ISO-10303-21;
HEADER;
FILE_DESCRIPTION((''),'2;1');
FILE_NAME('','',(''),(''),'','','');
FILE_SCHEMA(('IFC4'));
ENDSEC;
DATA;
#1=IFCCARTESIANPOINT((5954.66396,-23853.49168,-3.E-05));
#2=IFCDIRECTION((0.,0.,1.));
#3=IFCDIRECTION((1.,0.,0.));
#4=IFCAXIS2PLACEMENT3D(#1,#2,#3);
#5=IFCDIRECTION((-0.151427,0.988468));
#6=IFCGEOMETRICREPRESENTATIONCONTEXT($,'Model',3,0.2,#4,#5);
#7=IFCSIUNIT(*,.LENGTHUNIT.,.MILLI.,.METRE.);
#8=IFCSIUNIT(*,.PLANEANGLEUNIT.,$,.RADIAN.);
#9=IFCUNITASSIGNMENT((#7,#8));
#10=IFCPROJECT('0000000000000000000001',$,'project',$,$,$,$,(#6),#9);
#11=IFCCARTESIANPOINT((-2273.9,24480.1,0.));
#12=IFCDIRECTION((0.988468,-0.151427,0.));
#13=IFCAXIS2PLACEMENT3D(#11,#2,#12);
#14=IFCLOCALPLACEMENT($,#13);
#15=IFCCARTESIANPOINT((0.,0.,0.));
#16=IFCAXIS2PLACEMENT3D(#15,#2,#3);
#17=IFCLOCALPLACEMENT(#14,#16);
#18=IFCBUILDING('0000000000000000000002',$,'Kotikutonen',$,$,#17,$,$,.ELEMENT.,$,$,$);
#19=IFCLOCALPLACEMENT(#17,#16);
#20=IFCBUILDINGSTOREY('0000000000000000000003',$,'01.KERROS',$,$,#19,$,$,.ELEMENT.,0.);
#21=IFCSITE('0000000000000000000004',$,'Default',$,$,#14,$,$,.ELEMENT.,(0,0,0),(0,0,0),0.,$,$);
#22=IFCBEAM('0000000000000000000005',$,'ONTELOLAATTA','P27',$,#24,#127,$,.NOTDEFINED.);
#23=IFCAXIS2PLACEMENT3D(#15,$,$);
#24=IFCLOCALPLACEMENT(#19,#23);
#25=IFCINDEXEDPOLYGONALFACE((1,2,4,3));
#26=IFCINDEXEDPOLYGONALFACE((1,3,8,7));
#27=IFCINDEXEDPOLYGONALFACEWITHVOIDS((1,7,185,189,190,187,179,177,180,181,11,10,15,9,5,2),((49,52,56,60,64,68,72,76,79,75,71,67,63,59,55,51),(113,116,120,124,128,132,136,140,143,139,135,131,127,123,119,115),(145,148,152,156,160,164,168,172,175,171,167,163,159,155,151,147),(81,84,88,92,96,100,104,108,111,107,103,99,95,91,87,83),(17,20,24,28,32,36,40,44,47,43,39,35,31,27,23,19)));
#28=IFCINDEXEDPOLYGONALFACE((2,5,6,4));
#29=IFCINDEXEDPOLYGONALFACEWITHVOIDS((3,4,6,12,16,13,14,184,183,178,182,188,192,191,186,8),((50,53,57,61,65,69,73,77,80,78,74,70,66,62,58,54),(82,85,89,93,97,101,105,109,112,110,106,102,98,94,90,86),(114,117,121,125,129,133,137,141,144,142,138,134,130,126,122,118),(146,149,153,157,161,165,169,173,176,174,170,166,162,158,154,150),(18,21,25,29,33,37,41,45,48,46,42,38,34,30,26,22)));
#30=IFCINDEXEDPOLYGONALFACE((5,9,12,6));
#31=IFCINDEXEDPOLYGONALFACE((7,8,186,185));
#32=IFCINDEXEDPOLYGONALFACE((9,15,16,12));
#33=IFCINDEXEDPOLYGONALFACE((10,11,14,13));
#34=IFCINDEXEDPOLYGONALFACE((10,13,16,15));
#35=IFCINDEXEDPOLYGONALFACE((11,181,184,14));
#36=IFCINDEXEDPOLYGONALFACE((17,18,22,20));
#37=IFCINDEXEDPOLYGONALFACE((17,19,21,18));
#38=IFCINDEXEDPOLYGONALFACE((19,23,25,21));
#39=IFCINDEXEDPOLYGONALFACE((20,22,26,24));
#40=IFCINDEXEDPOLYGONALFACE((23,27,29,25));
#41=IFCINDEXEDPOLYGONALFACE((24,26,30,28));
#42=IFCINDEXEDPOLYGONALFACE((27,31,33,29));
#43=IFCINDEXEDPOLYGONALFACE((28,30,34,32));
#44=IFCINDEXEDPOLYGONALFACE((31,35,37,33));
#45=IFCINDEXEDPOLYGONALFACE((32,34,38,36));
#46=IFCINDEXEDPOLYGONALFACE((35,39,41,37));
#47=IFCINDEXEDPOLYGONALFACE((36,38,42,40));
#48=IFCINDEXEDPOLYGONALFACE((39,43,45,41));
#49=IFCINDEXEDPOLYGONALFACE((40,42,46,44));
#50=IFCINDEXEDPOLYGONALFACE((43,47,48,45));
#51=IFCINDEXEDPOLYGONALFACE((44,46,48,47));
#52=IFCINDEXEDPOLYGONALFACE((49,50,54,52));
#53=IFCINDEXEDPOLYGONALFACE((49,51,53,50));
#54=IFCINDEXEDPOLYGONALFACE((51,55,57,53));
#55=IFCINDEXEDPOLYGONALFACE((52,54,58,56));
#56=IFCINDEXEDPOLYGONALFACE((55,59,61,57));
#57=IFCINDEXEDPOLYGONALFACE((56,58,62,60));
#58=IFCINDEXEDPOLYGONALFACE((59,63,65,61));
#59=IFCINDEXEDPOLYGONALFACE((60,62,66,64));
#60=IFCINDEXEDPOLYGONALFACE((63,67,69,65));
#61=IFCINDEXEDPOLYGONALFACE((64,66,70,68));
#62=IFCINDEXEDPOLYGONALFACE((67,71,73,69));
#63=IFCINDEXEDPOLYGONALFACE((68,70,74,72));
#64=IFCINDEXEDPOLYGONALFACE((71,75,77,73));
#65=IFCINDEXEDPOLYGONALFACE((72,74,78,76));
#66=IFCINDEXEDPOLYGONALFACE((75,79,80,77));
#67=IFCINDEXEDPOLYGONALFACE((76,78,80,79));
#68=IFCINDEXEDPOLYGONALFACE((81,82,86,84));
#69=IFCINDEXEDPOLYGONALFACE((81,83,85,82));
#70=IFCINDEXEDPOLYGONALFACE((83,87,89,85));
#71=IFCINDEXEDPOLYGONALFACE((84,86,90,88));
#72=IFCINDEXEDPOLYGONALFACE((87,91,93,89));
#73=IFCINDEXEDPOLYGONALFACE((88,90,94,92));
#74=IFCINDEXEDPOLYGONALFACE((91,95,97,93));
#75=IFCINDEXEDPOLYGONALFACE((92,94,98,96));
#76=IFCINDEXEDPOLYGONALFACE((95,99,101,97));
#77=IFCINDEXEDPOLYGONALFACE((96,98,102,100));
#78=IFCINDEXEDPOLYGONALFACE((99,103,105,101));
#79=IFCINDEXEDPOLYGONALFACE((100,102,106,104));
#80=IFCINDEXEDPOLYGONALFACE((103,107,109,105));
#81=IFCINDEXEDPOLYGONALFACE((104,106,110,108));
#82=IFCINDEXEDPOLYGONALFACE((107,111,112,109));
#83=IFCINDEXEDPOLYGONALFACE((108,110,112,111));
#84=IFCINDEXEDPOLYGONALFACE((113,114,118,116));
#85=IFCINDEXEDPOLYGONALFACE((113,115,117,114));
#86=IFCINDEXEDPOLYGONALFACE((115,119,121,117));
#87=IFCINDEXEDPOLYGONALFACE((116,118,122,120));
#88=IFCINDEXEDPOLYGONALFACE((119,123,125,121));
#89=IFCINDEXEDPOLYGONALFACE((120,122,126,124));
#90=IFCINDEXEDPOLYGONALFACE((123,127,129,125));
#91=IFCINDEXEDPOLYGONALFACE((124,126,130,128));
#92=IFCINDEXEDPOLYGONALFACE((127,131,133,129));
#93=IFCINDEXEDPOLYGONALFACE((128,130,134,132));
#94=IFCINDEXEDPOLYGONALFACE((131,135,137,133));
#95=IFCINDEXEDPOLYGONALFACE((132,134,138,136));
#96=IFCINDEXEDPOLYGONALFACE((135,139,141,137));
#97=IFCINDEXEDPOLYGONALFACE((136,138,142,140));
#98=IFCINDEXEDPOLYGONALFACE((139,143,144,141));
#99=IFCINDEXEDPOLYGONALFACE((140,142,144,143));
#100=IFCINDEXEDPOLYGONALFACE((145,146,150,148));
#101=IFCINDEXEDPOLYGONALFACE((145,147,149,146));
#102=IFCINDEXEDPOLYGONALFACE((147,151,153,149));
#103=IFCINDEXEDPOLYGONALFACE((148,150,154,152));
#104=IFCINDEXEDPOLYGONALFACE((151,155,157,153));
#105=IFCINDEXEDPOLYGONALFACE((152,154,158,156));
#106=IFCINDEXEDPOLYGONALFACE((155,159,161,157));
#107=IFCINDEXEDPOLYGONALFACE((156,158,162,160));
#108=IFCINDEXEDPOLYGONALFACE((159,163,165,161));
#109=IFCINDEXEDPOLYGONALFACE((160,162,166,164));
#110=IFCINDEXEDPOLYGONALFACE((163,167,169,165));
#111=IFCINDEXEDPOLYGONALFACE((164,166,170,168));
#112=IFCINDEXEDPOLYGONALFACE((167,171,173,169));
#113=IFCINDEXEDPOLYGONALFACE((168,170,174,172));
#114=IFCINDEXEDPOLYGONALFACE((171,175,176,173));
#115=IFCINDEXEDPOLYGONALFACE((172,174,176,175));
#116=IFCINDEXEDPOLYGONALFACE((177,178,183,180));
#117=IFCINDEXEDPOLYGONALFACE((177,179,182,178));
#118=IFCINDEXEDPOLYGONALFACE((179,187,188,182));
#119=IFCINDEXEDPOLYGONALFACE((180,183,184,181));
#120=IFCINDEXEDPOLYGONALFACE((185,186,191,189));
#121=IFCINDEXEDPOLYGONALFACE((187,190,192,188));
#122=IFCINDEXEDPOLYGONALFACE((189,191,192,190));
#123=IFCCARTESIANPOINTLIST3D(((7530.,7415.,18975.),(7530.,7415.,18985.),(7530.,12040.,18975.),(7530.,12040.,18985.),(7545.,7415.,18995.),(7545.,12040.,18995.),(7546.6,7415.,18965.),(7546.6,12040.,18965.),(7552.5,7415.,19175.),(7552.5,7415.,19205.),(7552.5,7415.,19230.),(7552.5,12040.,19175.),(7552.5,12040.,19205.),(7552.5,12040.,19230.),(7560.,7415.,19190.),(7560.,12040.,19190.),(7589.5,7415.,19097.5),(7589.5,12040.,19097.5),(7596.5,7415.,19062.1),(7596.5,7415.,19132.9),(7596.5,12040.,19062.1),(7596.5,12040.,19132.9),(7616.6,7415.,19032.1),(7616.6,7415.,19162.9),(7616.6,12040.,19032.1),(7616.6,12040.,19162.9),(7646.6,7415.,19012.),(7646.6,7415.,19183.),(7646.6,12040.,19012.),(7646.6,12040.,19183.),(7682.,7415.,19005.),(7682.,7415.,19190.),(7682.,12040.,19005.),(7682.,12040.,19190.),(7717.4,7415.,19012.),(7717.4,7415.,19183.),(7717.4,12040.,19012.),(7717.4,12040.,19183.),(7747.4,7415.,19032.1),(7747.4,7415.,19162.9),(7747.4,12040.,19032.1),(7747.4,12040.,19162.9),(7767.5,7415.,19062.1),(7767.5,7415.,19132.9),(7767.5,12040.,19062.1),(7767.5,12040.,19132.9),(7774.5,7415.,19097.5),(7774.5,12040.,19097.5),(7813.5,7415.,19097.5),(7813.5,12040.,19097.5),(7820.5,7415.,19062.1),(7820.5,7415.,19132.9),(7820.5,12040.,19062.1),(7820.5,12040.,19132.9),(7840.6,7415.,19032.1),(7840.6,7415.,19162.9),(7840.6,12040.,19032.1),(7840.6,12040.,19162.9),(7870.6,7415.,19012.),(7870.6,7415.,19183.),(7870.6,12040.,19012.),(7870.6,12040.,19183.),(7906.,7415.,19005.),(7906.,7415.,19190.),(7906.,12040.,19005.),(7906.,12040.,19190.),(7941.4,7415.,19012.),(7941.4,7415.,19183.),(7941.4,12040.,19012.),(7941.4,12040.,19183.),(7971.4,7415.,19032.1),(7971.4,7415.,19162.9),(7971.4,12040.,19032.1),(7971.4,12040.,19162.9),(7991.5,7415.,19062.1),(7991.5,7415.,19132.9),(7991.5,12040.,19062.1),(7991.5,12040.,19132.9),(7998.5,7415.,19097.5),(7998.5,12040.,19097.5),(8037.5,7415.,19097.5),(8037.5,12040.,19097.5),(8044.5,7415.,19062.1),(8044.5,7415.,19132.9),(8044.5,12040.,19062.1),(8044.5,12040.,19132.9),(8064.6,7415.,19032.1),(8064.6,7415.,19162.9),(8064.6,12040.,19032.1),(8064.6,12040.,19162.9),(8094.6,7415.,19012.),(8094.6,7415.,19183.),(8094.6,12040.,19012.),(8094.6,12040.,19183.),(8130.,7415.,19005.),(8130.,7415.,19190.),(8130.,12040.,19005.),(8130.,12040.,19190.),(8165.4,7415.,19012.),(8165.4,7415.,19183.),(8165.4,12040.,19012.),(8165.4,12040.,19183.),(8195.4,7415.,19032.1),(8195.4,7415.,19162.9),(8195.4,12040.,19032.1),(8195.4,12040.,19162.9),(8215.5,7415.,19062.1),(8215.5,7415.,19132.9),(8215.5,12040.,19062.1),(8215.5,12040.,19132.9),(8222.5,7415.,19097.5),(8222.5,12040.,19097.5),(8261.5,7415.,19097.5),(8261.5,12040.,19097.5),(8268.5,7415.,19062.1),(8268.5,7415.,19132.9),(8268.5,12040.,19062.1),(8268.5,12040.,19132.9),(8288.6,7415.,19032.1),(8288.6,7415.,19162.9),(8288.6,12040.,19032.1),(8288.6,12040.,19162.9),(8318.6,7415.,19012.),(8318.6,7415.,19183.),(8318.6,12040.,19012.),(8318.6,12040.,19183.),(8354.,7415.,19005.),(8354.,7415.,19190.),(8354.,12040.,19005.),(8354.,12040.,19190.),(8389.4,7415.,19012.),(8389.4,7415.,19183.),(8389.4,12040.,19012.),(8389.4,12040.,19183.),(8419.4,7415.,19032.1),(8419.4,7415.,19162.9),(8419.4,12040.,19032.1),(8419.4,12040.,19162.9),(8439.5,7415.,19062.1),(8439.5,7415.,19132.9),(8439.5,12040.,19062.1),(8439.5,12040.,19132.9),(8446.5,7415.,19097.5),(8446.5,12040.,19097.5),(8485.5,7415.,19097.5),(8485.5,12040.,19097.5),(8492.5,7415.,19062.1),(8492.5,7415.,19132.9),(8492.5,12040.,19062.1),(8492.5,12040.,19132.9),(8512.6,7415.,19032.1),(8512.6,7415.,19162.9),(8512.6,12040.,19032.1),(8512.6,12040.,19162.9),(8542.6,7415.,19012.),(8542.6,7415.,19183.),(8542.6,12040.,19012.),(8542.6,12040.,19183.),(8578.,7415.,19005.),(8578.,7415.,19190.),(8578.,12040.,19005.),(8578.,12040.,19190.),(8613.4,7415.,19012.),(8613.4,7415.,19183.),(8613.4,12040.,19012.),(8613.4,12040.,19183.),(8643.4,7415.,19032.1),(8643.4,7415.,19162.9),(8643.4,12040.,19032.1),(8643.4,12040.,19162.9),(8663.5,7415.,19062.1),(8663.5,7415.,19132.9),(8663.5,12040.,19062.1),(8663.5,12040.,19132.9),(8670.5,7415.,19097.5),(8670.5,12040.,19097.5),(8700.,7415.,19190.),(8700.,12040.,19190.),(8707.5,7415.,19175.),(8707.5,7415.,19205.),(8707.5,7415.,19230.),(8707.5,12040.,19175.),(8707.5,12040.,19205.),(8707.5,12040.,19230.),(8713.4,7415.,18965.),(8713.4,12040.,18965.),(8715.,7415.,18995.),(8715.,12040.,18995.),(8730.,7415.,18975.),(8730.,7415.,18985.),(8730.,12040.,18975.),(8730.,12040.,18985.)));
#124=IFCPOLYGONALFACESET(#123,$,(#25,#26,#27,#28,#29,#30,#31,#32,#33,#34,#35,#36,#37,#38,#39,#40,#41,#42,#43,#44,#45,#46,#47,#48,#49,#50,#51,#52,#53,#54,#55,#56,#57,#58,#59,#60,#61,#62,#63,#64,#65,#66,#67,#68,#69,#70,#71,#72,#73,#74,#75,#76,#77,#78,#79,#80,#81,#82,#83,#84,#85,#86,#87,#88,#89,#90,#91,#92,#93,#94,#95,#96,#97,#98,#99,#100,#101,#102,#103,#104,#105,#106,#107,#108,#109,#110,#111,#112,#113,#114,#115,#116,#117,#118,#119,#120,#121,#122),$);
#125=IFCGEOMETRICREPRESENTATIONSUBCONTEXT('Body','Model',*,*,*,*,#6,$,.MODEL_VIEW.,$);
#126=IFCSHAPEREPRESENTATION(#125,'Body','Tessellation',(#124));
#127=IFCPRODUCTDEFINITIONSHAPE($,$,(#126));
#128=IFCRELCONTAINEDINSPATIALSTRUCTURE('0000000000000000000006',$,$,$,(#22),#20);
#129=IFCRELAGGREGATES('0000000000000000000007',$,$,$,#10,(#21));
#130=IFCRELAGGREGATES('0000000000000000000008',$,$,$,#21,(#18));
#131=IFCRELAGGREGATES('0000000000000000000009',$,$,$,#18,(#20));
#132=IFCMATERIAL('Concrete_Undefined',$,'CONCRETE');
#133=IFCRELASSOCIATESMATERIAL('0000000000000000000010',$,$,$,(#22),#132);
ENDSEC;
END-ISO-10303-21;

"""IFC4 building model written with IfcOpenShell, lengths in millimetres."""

from ifc_helpers import new_model, si_unit, direction, frame, origin_with_axes, place, context, subcontext, project, spatial, line, indexed_curve, outline, extrude, material, element, save


model = new_model("IFC4")

# Units and contexts
model_context = context("Model", 3, precision=0.2, world=frame((5954.66396, -23853.49168, -3e-05), z_axis=(0.0, 0.0, 1.0), x_axis=(1.0, 0.0, 0.0)), true_north=direction((-0.151427, 0.988468)))
body_context = subcontext(model_context, "Body", "Model", "MODEL_VIEW")
ifc_project = project(units=[si_unit("LENGTHUNIT", "METRE", prefix="MILLI"), si_unit("PLANEANGLEUNIT", "RADIAN")], contexts=[model_context])

# Site, building, storey
site_placement = place(None, frame((-2273.9, 24480.1, 0.0), z_axis=(0.0, 0.0, 1.0), x_axis=(0.988468, -0.151427, 0.0)))
site = spatial("IfcSite", under=ifc_project, at=site_placement, Name="Default", CompositionType="ELEMENT", RefLatitude=(0, 0, 0), RefLongitude=(0, 0, 0), RefElevation=0.0)
building_placement = place(site_placement, origin_with_axes())
building = spatial("IfcBuilding", under=site, at=building_placement, Name="Kotikutonen", CompositionType="ELEMENT")
storey_placement = place(building_placement, origin_with_axes())
storey = spatial("IfcBuildingStorey", under=building, at=storey_placement, Name="01.KERROS", CompositionType="ELEMENT", Elevation=0.0)

# Shared definitions
ifc_material_1 = material(Name="Concrete_Undefined", Category="CONCRETE")

# Beam
beam_1_placement = place(storey_placement, frame((8130.0, 12040.0, 19097.5), z_axis=(-1.0, 0.0, 0.0), x_axis=(0.0, -1.0, 0.0)))
element("IfcBeam", 1, at=beam_1_placement, inside=storey, material=ifc_material_1, Name="ONTELOLAATTA", Description="P27", PredefinedType="NOTDEFINED", context=body_context, shape_type="SolidModel", body=[
    extrude(outline(indexed_curve([(-600.0, -122.5), (-583.4, -132.5), (583.4, -132.5), (600.0, -122.5), (600.0, -112.5), (585.0, -102.5), (577.5, 77.5), (570.0, 92.5), (577.5, 107.5), (577.5, 132.5), (-577.5, 132.5), (-577.5, 107.5), (-570.0, 92.5), (-577.5, 77.5), (-585.0, -102.5), (-600.0, -112.5)], segments=[line(1, 2, 3, 4, 5, 6, 7, 8, 9, 10, 11, 12, 13, 14, 15, 16, 1)]), holes=[indexed_curve([(-448.0, -92.5), (-483.4, -85.5), (-513.4, -65.4), (-533.5, -35.4), (-540.5, 0.0), (-533.5, 35.4), (-513.4, 65.4), (-483.4, 85.5), (-448.0, 92.5), (-412.6, 85.5), (-382.6, 65.4), (-362.5, 35.4), (-355.5, 0.0), (-362.5, -35.4), (-382.6, -65.4), (-412.6, -85.5)], segments=[line(1, 2, 3, 4, 5, 6, 7, 8, 9, 10, 11, 12, 13, 14, 15, 16, 1)]), indexed_curve([(-224.0, -92.5), (-259.4, -85.5), (-289.4, -65.4), (-309.5, -35.4), (-316.5, 0.0), (-309.5, 35.4), (-289.4, 65.4), (-259.4, 85.5), (-224.0, 92.5), (-188.6, 85.5), (-158.6, 65.4), (-138.5, 35.4), (-131.5, 0.0), (-138.5, -35.4), (-158.6, -65.4), (-188.6, -85.5)], segments=[line(1, 2, 3, 4, 5, 6, 7, 8, 9, 10, 11, 12, 13, 14, 15, 16, 1)]), indexed_curve([(0.0, -92.5), (-35.4, -85.5), (-65.4, -65.4), (-85.5, -35.4), (-92.5, 0.0), (-85.5, 35.4), (-65.4, 65.4), (-35.4, 85.5), (0.0, 92.5), (35.4, 85.5), (65.4, 65.4), (85.5, 35.4), (92.5, 0.0), (85.5, -35.4), (65.4, -65.4), (35.4, -85.5)], segments=[line(1, 2, 3, 4, 5, 6, 7, 8, 9, 10, 11, 12, 13, 14, 15, 16, 1)]), indexed_curve([(224.0, -92.5), (188.6, -85.5), (158.6, -65.4), (138.5, -35.4), (131.5, 0.0), (138.5, 35.4), (158.6, 65.4), (188.6, 85.5), (224.0, 92.5), (259.4, 85.5), (289.4, 65.4), (309.5, 35.4), (316.5, 0.0), (309.5, -35.4), (289.4, -65.4), (259.4, -85.5)], segments=[line(1, 2, 3, 4, 5, 6, 7, 8, 9, 10, 11, 12, 13, 14, 15, 16, 1)]), indexed_curve([(448.0, -92.5), (412.6, -85.5), (382.6, -65.4), (362.5, -35.4), (355.5, 0.0), (362.5, 35.4), (382.6, 65.4), (412.6, 85.5), (448.0, 92.5), (483.4, 85.5), (513.4, 65.4), (533.5, 35.4), (540.5, 0.0), (533.5, -35.4), (513.4, -65.4), (483.4, -85.5)], segments=[line(1, 2, 3, 4, 5, 6, 7, 8, 9, 10, 11, 12, 13, 14, 15, 16, 1)])]), frame((0.0, 0.0, 0.0), z_axis=(-1.0, 0.0, 0.0), x_axis=(0.0, 0.0, 1.0)), (0.0, 0.0, -1.0), 4625.0),
])

save(model, "model.ifc")
